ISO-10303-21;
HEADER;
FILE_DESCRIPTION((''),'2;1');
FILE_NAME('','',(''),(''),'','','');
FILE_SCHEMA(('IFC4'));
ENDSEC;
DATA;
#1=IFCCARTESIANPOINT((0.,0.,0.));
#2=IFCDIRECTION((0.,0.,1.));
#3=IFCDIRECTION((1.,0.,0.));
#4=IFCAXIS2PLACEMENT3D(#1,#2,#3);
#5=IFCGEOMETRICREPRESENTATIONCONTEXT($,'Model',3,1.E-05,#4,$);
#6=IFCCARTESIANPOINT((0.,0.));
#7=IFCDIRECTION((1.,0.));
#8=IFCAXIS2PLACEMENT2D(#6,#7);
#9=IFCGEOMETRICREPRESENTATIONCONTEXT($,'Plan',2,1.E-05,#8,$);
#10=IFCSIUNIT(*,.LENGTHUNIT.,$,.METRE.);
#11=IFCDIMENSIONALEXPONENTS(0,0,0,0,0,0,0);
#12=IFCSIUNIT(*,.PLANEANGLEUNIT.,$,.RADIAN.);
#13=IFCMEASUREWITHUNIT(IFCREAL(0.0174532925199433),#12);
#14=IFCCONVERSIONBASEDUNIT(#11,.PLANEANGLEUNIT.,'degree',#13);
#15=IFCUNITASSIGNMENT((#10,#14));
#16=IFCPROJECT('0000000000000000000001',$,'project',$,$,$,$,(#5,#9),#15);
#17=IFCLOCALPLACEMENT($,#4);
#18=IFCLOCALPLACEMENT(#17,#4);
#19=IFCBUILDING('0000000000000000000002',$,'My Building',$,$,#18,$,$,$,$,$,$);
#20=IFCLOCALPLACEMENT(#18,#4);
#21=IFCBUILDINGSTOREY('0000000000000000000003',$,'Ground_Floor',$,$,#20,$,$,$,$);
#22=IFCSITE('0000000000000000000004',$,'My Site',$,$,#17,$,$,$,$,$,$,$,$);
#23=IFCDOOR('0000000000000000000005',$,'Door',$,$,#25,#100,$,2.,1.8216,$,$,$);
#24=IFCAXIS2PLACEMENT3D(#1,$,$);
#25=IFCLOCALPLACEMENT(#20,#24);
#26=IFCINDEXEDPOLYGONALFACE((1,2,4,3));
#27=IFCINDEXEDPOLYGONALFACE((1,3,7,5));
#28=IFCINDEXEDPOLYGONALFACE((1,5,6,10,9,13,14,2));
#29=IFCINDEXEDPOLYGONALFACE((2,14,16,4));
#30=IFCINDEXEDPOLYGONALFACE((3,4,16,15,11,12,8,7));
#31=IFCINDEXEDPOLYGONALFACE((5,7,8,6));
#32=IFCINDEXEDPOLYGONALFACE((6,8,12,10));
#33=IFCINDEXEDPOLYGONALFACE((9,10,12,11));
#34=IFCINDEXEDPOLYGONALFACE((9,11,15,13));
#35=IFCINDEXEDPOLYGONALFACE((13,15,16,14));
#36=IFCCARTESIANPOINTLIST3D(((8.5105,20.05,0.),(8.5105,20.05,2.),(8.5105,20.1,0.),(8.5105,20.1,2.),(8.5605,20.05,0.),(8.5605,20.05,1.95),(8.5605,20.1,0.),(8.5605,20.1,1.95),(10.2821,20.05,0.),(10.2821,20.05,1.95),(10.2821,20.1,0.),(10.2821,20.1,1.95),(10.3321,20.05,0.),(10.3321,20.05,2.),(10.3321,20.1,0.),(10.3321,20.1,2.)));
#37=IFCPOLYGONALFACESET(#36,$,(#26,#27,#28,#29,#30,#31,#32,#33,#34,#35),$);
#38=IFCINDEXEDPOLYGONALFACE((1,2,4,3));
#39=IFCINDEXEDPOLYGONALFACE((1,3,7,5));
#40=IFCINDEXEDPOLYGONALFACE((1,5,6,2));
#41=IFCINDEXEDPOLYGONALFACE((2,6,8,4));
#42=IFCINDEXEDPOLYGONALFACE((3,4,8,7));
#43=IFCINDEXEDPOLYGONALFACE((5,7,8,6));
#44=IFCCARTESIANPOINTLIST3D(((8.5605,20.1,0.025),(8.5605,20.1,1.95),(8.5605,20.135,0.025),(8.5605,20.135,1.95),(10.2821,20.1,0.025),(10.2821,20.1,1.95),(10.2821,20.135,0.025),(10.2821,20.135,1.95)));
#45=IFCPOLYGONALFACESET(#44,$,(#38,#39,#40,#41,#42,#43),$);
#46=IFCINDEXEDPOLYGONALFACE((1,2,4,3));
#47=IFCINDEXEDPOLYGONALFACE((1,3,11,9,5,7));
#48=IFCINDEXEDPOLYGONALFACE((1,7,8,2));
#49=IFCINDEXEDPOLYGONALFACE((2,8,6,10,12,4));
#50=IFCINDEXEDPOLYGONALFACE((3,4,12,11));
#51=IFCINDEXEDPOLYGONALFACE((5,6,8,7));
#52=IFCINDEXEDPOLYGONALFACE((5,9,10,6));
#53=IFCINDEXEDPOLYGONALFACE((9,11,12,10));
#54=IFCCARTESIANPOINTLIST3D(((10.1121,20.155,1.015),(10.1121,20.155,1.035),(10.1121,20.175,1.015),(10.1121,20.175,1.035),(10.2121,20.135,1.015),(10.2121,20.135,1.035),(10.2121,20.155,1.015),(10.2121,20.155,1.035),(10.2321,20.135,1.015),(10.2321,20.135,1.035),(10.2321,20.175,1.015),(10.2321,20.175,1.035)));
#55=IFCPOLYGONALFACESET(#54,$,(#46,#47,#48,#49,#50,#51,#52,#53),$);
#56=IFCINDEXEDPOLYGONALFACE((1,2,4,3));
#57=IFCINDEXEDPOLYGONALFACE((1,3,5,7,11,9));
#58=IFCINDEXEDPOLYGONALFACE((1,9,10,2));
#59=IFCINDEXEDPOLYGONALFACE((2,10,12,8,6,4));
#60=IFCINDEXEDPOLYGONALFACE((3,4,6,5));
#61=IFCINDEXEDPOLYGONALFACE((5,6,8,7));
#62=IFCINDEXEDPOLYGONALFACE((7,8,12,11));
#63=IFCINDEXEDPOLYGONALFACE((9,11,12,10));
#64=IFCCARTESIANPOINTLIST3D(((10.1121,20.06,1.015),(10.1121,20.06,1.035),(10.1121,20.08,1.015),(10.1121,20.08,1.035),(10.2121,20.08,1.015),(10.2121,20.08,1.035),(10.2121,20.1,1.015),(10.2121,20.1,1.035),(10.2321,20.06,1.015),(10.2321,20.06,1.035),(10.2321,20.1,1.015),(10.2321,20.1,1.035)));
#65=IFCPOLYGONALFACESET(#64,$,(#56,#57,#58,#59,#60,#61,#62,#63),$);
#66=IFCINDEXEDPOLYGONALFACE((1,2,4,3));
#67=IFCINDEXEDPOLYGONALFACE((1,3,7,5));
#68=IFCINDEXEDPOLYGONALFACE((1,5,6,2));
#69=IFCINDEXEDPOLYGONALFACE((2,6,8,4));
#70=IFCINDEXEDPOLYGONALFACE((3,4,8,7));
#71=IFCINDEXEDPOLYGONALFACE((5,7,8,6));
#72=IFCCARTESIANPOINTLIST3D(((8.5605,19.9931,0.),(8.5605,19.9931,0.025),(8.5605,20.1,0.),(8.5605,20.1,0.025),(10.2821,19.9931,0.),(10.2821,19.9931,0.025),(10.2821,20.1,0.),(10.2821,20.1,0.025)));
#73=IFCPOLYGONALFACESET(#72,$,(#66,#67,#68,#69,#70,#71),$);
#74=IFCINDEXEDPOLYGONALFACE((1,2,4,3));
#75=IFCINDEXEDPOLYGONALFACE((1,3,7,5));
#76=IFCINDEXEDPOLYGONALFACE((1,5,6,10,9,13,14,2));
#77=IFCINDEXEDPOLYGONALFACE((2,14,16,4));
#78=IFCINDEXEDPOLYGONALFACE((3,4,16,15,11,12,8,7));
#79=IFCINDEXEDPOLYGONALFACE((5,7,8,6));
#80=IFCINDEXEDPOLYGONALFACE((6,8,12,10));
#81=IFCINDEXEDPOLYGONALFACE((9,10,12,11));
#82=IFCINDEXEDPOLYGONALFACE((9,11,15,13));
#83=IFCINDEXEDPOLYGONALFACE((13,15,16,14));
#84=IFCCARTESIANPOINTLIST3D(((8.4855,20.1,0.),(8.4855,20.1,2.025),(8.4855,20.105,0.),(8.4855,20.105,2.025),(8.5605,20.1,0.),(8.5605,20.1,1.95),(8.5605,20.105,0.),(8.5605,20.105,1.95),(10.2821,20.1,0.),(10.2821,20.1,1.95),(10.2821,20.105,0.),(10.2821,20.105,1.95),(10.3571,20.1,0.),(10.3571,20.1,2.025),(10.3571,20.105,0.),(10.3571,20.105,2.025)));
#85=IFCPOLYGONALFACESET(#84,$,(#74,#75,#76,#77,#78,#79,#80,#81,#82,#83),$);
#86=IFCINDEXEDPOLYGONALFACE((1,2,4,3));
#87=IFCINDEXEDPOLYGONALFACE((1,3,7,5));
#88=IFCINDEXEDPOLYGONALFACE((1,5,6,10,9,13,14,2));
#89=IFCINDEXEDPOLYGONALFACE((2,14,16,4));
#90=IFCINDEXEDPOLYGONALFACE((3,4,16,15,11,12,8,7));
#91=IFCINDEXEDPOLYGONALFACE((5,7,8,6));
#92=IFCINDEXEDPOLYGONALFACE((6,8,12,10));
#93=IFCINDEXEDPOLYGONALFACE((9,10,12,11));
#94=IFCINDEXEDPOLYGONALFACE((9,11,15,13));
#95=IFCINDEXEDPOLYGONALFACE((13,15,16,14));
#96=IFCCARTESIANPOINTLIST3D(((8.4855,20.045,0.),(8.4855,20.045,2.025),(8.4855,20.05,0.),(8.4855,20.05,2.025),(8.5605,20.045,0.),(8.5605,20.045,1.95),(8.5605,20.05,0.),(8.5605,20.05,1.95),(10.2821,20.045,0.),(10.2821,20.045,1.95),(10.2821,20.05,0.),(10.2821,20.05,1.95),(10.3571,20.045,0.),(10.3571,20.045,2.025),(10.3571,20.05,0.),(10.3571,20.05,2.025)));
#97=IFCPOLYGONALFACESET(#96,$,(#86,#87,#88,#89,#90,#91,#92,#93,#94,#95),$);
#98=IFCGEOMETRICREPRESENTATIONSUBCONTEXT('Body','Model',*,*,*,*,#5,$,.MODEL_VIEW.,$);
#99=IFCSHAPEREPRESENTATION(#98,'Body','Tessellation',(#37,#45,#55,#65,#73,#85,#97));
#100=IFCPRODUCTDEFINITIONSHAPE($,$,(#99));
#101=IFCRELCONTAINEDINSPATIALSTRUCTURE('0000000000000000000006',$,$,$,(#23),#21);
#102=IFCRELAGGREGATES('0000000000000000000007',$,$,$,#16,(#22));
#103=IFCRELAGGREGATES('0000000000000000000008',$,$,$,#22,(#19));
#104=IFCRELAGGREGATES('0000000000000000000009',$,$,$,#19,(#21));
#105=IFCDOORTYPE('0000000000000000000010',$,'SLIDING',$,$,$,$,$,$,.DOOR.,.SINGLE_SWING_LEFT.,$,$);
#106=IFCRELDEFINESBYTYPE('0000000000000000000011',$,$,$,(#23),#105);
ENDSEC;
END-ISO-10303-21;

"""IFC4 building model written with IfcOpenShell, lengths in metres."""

from ifc_helpers import new_model, entity, si_unit, converted_unit, frame, origin_with_axes, origin_2d_with_axis, place, context, subcontext, project, spatial, line, indexed_curve, outline, extrude, shape, source, transform, mapped, type_object, type_shapes, element, save


model = new_model("IFC4")

# Units and contexts
model_context = context("Model", 3, precision=1e-05, world=origin_with_axes())
plan_context = context("Plan", 2, precision=1e-05, world=origin_2d_with_axis())
body_context_1 = subcontext(model_context, "Body", "Model", "MODEL_VIEW")
body_context_2 = subcontext(plan_context, "Body", "Plan", "PLAN_VIEW")
ifc_project = project(units=[si_unit("LENGTHUNIT", "METRE"), converted_unit("PLANEANGLEUNIT", "degree", entity("IfcReal", 0.0174532925199433), si_unit("PLANEANGLEUNIT", "RADIAN"), dimensions=[0, 0, 0, 0, 0, 0, 0])], contexts=[model_context, plan_context])

# Site, building, storey
site_placement = place(None, origin_with_axes())
site = spatial("IfcSite", under=ifc_project, at=site_placement, Name="My Site")
building_placement = place(site_placement, origin_with_axes())
building = spatial("IfcBuilding", under=site, at=building_placement, Name="My Building")
storey_placement = place(building_placement, origin_with_axes())
storey = spatial("IfcBuildingStorey", under=building, at=storey_placement, Name="Ground_Floor")

# Door
door_type_1 = type_object("IfcDoorType", Name="SLIDING", OperationType="SINGLE_SWING_LEFT", PredefinedType="DOOR")
shared_shape_1 = source(origin_with_axes(), body_context_1, "Body", "SweptSolid", [
    extrude(outline(indexed_curve([(0.0, 0.0), (0.0, 2.0), (1.8216, 2.0), (1.8216, 0.0), (1.7716, 0.0), (1.7716, 1.95), (0.05, 1.95), (0.05, 0.0)], segments=[line(1, 2, 3, 4, 5, 6, 7, 8, 1)])), frame((0.0, 0.0, 0.0), z_axis=(0.0, -1.0, 0.0), x_axis=(1.0, 0.0, 0.0)), (0.0, 0.0, -1.0), 0.05),
    extrude(outline(indexed_curve([(0.0, 0.0), (1.7216, 0.0), (1.7216, 0.035), (0.0, 0.035)], segments=[line(1, 2, 3, 4, 1)])), frame((0.05, -0.035, 0.025), z_axis=(0.0, 0.0, 1.0), x_axis=(1.0, 0.0, 0.0)), (0.0, 0.0, 1.0), 1.925),
    extrude(outline(indexed_curve([(0.0, 0.0), (0.0, -0.04), (0.12, -0.04), (0.12, -0.02), (0.02, -0.02), (0.02, 0.0)], segments=[line(1, 2, 3, 4, 5, 6, 1)])), frame((0.1, -0.035, 1.015), z_axis=(0.0, 0.0, 1.0), x_axis=(1.0, 0.0, 0.0)), (0.0, 0.0, 1.0), 0.02),
    extrude(outline(indexed_curve([(0.0, 0.0), (0.0, 0.04), (0.12, 0.04), (0.12, 0.02), (0.02, 0.02), (0.02, 0.0)], segments=[line(1, 2, 3, 4, 5, 6, 1)])), frame((0.1, 0.0, 1.015), z_axis=(0.0, 0.0, 1.0), x_axis=(1.0, 0.0, 0.0)), (0.0, 0.0, 1.0), 0.02),
    extrude(outline(indexed_curve([(0.0, 0.0), (1.7216, 0.0), (1.7216, 0.1069), (0.0, 0.1069)], segments=[line(1, 2, 3, 4, 1)])), frame((0.05, 0.0, 0.0), z_axis=(0.0, 0.0, 1.0), x_axis=(1.0, 0.0, 0.0)), (0.0, 0.0, 1.0), 0.025),
    extrude(outline(indexed_curve([(0.0, 0.0), (0.0, 2.025), (1.8716, 2.025), (1.8716, 0.0), (1.7966, 0.0), (1.7966, 1.95), (0.075, 1.95), (0.075, 0.0)], segments=[line(1, 2, 3, 4, 5, 6, 7, 8, 1)])), frame((-0.025, -0.005, 0.0), z_axis=(0.0, -1.0, 0.0), x_axis=(1.0, 0.0, 0.0)), (0.0, 0.0, -1.0), 0.005),
    extrude(outline(indexed_curve([(0.0, 0.0), (0.0, 2.025), (1.8716, 2.025), (1.8716, 0.0), (1.7966, 0.0), (1.7966, 1.95), (0.075, 1.95), (0.075, 0.0)], segments=[line(1, 2, 3, 4, 5, 6, 7, 8, 1)])), frame((-0.025, 0.05, 0.0), z_axis=(0.0, -1.0, 0.0), x_axis=(1.0, 0.0, 0.0)), (0.0, 0.0, -1.0), 0.005),
])
shared_shape_2 = source(origin_with_axes(), body_context_2, "Body", "Curve2D", [
    entity("IfcIndexedPolyCurve", entity("IfcCartesianPointList2D", [[0.0, 0.0], [0.05, 0.0], [0.05, 0.05], [0.0, 0.05]]), [entity("IfcLineIndex", [1, 2, 3, 4, 1])]),
    entity("IfcIndexedPolyCurve", entity("IfcCartesianPointList2D", [[1.8216, 0.0], [1.7716, 0.0], [1.7716, 0.05], [1.8216, 0.05]]), [entity("IfcLineIndex", [1, 2, 3, 4, 1])]),
    entity("IfcIndexedPolyCurve", entity("IfcCartesianPointList2D", [[2.6325, -0.035], [0.9108, -0.035], [0.9108, 0.0], [2.6325, 0.0]]), [entity("IfcLineIndex", [1, 2, 3, 4, 1])]),
])
type_shapes(door_type_1, [shared_shape_1, shared_shape_2])
door_1_placement = place(storey_placement, frame((10.3321, 20.1, 0.0), z_axis=(0.0, 0.0, 1.0), x_axis=(-1.0, 0.0, 0.0)))
element("IfcDoor", 1, at=door_1_placement, inside=storey, type_object=door_type_1, Name="Door", OverallHeight=2.0, OverallWidth=1.8216, shapes=[
    shape(body_context_1, "Body", "MappedRepresentation", [mapped(shared_shape_1, transform((0.0, 0.0, 0.0), x_axis=(1.0, 0.0, 0.0), y_axis=(0.0, 1.0, 0.0), z_axis=(0.0, 0.0, 1.0), scale=1.0))]),
    shape(body_context_2, "Body", "MappedRepresentation", [mapped(shared_shape_2, transform((0.0, 0.0, 0.0), x_axis=(1.0, 0.0, 0.0), y_axis=(0.0, 1.0, 0.0), z_axis=(0.0, 0.0, 1.0), scale=1.0))]),
])

save(model, "model.ifc")
